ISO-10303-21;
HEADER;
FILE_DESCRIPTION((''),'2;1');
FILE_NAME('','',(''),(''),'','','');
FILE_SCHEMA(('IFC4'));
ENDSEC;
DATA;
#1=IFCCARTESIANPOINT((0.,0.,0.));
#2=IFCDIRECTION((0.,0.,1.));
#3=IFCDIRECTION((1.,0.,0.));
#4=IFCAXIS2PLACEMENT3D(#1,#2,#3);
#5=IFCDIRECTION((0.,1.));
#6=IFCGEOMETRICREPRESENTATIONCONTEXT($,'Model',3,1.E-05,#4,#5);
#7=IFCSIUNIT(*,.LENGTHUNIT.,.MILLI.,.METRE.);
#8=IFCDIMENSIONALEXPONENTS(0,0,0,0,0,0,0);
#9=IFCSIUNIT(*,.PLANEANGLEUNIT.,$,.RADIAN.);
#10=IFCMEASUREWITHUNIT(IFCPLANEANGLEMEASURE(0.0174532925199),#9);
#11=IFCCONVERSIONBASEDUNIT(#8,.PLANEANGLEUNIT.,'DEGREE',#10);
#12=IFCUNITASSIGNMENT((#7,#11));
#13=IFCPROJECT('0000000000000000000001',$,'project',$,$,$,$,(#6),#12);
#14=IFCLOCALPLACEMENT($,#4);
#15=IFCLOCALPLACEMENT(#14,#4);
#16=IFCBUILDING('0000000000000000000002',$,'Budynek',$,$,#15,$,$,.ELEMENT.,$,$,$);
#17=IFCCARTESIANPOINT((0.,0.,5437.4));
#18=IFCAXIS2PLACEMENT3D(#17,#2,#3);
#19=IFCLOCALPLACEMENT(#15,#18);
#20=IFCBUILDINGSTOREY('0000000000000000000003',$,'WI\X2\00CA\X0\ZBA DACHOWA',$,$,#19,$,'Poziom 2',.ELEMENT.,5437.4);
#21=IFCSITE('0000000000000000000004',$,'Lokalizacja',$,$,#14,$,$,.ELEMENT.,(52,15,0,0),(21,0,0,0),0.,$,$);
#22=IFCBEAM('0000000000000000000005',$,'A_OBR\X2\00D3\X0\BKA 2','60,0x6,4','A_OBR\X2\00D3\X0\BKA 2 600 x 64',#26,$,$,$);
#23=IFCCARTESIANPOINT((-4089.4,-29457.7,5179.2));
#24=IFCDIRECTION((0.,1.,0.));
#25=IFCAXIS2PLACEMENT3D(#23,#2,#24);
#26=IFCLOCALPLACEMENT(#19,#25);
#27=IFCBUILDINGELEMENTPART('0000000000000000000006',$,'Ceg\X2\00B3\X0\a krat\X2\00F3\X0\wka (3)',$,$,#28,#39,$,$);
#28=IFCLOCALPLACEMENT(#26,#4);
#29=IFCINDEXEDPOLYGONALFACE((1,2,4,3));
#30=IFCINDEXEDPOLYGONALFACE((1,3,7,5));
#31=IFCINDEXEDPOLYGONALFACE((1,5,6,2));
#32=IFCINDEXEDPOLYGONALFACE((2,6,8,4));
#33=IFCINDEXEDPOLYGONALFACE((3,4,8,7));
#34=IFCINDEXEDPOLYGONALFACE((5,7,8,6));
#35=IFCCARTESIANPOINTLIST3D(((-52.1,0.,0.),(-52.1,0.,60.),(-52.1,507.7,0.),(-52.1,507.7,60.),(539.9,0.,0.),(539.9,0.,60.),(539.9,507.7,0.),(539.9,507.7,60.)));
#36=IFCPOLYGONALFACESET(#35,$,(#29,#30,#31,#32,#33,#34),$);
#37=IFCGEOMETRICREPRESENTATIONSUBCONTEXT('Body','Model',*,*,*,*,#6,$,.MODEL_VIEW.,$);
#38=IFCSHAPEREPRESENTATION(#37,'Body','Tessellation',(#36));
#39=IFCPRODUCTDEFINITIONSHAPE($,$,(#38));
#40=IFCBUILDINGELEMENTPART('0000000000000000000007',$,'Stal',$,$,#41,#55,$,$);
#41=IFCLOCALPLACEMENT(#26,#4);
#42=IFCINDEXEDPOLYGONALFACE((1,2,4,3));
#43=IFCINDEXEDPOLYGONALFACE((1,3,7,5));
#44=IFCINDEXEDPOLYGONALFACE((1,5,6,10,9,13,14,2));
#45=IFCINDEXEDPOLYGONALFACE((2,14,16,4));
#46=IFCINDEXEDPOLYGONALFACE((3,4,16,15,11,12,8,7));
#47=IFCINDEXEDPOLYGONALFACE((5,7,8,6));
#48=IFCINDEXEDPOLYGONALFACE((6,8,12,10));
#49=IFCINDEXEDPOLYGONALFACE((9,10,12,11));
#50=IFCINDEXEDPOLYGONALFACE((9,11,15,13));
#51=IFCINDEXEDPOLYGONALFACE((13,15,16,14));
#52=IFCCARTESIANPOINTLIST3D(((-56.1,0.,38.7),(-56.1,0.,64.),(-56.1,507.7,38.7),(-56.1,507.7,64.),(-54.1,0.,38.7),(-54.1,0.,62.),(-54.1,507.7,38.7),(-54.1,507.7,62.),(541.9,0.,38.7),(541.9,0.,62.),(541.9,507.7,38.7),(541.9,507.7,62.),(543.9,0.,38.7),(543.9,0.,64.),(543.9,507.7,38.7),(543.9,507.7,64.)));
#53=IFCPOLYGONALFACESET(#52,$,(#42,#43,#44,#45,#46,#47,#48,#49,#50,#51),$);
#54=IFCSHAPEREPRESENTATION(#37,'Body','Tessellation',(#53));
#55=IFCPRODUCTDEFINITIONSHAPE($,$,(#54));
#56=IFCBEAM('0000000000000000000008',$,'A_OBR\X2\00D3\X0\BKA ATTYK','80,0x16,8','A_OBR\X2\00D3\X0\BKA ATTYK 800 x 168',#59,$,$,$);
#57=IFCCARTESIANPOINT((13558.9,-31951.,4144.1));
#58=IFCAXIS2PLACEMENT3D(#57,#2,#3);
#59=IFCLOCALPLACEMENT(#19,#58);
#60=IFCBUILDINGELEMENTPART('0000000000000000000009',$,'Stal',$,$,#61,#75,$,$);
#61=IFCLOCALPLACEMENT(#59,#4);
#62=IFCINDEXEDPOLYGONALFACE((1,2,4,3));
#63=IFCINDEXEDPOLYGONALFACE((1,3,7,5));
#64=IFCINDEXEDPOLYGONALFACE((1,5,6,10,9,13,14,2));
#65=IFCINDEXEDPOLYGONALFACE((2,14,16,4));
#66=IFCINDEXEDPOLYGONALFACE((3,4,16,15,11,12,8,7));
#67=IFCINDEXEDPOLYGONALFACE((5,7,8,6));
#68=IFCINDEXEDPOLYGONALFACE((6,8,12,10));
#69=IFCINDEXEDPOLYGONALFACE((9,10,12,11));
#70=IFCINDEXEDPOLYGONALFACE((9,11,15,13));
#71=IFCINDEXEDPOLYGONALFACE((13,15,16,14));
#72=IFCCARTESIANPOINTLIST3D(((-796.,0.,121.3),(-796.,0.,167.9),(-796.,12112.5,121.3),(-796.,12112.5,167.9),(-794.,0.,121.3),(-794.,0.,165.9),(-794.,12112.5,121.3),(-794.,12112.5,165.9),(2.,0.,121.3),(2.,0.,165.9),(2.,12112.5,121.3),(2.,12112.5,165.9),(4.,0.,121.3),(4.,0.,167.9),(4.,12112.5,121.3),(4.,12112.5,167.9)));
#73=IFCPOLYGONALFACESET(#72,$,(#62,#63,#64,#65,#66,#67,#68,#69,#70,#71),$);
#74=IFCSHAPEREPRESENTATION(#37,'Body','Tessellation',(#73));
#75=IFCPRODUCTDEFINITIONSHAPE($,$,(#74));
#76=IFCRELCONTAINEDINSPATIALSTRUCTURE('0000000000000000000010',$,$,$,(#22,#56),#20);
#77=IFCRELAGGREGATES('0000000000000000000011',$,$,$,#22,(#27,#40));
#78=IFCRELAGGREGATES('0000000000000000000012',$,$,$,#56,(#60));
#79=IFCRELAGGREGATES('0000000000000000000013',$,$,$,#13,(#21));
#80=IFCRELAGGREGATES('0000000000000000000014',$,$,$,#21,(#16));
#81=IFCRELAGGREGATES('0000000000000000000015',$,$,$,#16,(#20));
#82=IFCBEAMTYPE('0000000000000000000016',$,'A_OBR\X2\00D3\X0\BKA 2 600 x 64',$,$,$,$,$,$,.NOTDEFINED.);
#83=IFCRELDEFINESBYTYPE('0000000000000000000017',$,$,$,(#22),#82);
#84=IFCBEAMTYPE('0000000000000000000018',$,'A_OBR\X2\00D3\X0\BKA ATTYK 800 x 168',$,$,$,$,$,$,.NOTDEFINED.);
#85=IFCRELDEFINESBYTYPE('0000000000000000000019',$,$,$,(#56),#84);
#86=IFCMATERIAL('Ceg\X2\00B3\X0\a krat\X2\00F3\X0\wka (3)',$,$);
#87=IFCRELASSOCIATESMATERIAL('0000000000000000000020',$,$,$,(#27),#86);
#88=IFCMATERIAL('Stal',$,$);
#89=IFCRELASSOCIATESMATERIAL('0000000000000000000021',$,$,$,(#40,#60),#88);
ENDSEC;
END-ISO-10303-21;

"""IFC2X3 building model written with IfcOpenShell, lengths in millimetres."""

from ifc_helpers import new_model, entity, si_unit, converted_unit, direction, frame, origin_with_axes, place, context, subcontext, project, spatial, polyline, outline, extrude, material, type_object, element, aggregate, save


model = new_model("IFC2X3")

# Units and contexts
model_context = context("Model", 3, precision=1e-05, world=origin_with_axes(), true_north=direction((0.0, 1.0)))
body_context = subcontext(model_context, "Body", "Model", "MODEL_VIEW")
ifc_project = project(units=[si_unit("LENGTHUNIT", "METRE", prefix="MILLI"), converted_unit("PLANEANGLEUNIT", "DEGREE", entity("IfcPlaneAngleMeasure", 0.0174532925199), si_unit("PLANEANGLEUNIT", "RADIAN"), dimensions=[0, 0, 0, 0, 0, 0, 0])], contexts=[model_context])

# Site, building, storey
site_placement = place(None, origin_with_axes())
site = spatial("IfcSite", under=ifc_project, at=site_placement, Name="Lokalizacja", CompositionType="ELEMENT", RefLatitude=(52, 15, 0, 0), RefLongitude=(21, 0, 0, 0), RefElevation=0.0)
building_placement = place(site_placement, origin_with_axes())
building = spatial("IfcBuilding", under=site, at=building_placement, Name="Budynek", CompositionType="ELEMENT")
storey_placement = place(building_placement, frame((0.0, 0.0, 5437.4), z_axis=(0.0, 0.0, 1.0), x_axis=(1.0, 0.0, 0.0)))
storey = spatial("IfcBuildingStorey", under=building, at=storey_placement, Name="WIÊZBA DACHOWA", LongName="Poziom 2", CompositionType="ELEMENT", Elevation=5437.4)

# Shared definitions
ifc_material_1 = material(Name="Ceg³a kratówka (3)")

# Beams, building element parts
beam_type_1 = type_object("IfcBeamType", Name="A_OBRÓBKA ATTYK 800 x 168", PredefinedType="NOTDEFINED")
ifc_material_2 = material(Name="Stal")
beam_type_2 = type_object("IfcBeamType", Name="A_OBRÓBKA 2 600 x 64", PredefinedType="NOTDEFINED")
beam_1_placement = place(storey_placement, frame((-4089.4, -29457.7, 5179.2), z_axis=(0.0, 0.0, 1.0), x_axis=(0.0, 1.0, 0.0)))
beam_1 = element("IfcBeam", 1, at=beam_1_placement, inside=storey, type_object=beam_type_2, Name="A_OBRÓBKA 2", Description="60,0x6,4", ObjectType="A_OBRÓBKA 2 600 x 64")
building_element_part_1_placement = place(beam_1_placement, origin_with_axes())
building_element_part_1 = element("IfcBuildingElementPart", 2, at=building_element_part_1_placement, material=ifc_material_1, Name="Ceg³a kratówka (3)", context=body_context, shape_type="SweptSolid", body=[
    extrude(outline(polyline([(539.9, 0.0), (539.9, 60.0), (-52.1, 60.0), (-52.1, 0.0), (539.9, 0.0)])), frame((0.0, 507.7, 0.0), z_axis=(0.0, -1.0, 0.0), x_axis=(1.0, 0.0, 0.0)), (0.0, 0.0, 1.0), 507.7),
])
building_element_part_2_placement = place(beam_1_placement, origin_with_axes())
building_element_part_2 = element("IfcBuildingElementPart", 3, at=building_element_part_2_placement, material=ifc_material_2, Name="Stal", context=body_context, shape_type="SweptSolid", body=[
    extrude(outline(polyline([(-56.1, 64.0), (-56.1, 38.7), (-54.1, 38.7), (-54.1, 62.0), (541.9, 62.0), (541.9, 38.7), (543.9, 38.7), (543.9, 64.0), (-56.1, 64.0)])), frame((0.0, 507.7, 0.0), z_axis=(0.0, -1.0, 0.0), x_axis=(1.0, 0.0, 0.0)), (0.0, 0.0, 1.0), 507.7),
])
aggregate(beam_1, [building_element_part_1, building_element_part_2])
beam_2_placement = place(storey_placement, frame((13558.9, -31951.0, 4144.1), z_axis=(0.0, 0.0, 1.0), x_axis=(1.0, 0.0, 0.0)))
beam_2 = element("IfcBeam", 4, at=beam_2_placement, inside=storey, type_object=beam_type_1, Name="A_OBRÓBKA ATTYK", Description="80,0x16,8", ObjectType="A_OBRÓBKA ATTYK 800 x 168")
building_element_part_3_placement = place(beam_2_placement, origin_with_axes())
building_element_part_3 = element("IfcBuildingElementPart", 5, at=building_element_part_3_placement, material=ifc_material_2, Name="Stal", context=body_context, shape_type="SweptSolid", body=[
    extrude(outline(polyline([(-796.0, 167.9), (-796.0, 121.3), (-794.0, 121.3), (-794.0, 165.9), (2.0, 165.9), (2.0, 121.3), (4.0, 121.3), (4.0, 167.9), (-796.0, 167.9)])), frame((0.0, 12112.5, 0.0), z_axis=(0.0, -1.0, 0.0), x_axis=(1.0, 0.0, 0.0)), (0.0, 0.0, 1.0), 12112.5),
])
aggregate(beam_2, [building_element_part_3])

save(model, "model.ifc")
